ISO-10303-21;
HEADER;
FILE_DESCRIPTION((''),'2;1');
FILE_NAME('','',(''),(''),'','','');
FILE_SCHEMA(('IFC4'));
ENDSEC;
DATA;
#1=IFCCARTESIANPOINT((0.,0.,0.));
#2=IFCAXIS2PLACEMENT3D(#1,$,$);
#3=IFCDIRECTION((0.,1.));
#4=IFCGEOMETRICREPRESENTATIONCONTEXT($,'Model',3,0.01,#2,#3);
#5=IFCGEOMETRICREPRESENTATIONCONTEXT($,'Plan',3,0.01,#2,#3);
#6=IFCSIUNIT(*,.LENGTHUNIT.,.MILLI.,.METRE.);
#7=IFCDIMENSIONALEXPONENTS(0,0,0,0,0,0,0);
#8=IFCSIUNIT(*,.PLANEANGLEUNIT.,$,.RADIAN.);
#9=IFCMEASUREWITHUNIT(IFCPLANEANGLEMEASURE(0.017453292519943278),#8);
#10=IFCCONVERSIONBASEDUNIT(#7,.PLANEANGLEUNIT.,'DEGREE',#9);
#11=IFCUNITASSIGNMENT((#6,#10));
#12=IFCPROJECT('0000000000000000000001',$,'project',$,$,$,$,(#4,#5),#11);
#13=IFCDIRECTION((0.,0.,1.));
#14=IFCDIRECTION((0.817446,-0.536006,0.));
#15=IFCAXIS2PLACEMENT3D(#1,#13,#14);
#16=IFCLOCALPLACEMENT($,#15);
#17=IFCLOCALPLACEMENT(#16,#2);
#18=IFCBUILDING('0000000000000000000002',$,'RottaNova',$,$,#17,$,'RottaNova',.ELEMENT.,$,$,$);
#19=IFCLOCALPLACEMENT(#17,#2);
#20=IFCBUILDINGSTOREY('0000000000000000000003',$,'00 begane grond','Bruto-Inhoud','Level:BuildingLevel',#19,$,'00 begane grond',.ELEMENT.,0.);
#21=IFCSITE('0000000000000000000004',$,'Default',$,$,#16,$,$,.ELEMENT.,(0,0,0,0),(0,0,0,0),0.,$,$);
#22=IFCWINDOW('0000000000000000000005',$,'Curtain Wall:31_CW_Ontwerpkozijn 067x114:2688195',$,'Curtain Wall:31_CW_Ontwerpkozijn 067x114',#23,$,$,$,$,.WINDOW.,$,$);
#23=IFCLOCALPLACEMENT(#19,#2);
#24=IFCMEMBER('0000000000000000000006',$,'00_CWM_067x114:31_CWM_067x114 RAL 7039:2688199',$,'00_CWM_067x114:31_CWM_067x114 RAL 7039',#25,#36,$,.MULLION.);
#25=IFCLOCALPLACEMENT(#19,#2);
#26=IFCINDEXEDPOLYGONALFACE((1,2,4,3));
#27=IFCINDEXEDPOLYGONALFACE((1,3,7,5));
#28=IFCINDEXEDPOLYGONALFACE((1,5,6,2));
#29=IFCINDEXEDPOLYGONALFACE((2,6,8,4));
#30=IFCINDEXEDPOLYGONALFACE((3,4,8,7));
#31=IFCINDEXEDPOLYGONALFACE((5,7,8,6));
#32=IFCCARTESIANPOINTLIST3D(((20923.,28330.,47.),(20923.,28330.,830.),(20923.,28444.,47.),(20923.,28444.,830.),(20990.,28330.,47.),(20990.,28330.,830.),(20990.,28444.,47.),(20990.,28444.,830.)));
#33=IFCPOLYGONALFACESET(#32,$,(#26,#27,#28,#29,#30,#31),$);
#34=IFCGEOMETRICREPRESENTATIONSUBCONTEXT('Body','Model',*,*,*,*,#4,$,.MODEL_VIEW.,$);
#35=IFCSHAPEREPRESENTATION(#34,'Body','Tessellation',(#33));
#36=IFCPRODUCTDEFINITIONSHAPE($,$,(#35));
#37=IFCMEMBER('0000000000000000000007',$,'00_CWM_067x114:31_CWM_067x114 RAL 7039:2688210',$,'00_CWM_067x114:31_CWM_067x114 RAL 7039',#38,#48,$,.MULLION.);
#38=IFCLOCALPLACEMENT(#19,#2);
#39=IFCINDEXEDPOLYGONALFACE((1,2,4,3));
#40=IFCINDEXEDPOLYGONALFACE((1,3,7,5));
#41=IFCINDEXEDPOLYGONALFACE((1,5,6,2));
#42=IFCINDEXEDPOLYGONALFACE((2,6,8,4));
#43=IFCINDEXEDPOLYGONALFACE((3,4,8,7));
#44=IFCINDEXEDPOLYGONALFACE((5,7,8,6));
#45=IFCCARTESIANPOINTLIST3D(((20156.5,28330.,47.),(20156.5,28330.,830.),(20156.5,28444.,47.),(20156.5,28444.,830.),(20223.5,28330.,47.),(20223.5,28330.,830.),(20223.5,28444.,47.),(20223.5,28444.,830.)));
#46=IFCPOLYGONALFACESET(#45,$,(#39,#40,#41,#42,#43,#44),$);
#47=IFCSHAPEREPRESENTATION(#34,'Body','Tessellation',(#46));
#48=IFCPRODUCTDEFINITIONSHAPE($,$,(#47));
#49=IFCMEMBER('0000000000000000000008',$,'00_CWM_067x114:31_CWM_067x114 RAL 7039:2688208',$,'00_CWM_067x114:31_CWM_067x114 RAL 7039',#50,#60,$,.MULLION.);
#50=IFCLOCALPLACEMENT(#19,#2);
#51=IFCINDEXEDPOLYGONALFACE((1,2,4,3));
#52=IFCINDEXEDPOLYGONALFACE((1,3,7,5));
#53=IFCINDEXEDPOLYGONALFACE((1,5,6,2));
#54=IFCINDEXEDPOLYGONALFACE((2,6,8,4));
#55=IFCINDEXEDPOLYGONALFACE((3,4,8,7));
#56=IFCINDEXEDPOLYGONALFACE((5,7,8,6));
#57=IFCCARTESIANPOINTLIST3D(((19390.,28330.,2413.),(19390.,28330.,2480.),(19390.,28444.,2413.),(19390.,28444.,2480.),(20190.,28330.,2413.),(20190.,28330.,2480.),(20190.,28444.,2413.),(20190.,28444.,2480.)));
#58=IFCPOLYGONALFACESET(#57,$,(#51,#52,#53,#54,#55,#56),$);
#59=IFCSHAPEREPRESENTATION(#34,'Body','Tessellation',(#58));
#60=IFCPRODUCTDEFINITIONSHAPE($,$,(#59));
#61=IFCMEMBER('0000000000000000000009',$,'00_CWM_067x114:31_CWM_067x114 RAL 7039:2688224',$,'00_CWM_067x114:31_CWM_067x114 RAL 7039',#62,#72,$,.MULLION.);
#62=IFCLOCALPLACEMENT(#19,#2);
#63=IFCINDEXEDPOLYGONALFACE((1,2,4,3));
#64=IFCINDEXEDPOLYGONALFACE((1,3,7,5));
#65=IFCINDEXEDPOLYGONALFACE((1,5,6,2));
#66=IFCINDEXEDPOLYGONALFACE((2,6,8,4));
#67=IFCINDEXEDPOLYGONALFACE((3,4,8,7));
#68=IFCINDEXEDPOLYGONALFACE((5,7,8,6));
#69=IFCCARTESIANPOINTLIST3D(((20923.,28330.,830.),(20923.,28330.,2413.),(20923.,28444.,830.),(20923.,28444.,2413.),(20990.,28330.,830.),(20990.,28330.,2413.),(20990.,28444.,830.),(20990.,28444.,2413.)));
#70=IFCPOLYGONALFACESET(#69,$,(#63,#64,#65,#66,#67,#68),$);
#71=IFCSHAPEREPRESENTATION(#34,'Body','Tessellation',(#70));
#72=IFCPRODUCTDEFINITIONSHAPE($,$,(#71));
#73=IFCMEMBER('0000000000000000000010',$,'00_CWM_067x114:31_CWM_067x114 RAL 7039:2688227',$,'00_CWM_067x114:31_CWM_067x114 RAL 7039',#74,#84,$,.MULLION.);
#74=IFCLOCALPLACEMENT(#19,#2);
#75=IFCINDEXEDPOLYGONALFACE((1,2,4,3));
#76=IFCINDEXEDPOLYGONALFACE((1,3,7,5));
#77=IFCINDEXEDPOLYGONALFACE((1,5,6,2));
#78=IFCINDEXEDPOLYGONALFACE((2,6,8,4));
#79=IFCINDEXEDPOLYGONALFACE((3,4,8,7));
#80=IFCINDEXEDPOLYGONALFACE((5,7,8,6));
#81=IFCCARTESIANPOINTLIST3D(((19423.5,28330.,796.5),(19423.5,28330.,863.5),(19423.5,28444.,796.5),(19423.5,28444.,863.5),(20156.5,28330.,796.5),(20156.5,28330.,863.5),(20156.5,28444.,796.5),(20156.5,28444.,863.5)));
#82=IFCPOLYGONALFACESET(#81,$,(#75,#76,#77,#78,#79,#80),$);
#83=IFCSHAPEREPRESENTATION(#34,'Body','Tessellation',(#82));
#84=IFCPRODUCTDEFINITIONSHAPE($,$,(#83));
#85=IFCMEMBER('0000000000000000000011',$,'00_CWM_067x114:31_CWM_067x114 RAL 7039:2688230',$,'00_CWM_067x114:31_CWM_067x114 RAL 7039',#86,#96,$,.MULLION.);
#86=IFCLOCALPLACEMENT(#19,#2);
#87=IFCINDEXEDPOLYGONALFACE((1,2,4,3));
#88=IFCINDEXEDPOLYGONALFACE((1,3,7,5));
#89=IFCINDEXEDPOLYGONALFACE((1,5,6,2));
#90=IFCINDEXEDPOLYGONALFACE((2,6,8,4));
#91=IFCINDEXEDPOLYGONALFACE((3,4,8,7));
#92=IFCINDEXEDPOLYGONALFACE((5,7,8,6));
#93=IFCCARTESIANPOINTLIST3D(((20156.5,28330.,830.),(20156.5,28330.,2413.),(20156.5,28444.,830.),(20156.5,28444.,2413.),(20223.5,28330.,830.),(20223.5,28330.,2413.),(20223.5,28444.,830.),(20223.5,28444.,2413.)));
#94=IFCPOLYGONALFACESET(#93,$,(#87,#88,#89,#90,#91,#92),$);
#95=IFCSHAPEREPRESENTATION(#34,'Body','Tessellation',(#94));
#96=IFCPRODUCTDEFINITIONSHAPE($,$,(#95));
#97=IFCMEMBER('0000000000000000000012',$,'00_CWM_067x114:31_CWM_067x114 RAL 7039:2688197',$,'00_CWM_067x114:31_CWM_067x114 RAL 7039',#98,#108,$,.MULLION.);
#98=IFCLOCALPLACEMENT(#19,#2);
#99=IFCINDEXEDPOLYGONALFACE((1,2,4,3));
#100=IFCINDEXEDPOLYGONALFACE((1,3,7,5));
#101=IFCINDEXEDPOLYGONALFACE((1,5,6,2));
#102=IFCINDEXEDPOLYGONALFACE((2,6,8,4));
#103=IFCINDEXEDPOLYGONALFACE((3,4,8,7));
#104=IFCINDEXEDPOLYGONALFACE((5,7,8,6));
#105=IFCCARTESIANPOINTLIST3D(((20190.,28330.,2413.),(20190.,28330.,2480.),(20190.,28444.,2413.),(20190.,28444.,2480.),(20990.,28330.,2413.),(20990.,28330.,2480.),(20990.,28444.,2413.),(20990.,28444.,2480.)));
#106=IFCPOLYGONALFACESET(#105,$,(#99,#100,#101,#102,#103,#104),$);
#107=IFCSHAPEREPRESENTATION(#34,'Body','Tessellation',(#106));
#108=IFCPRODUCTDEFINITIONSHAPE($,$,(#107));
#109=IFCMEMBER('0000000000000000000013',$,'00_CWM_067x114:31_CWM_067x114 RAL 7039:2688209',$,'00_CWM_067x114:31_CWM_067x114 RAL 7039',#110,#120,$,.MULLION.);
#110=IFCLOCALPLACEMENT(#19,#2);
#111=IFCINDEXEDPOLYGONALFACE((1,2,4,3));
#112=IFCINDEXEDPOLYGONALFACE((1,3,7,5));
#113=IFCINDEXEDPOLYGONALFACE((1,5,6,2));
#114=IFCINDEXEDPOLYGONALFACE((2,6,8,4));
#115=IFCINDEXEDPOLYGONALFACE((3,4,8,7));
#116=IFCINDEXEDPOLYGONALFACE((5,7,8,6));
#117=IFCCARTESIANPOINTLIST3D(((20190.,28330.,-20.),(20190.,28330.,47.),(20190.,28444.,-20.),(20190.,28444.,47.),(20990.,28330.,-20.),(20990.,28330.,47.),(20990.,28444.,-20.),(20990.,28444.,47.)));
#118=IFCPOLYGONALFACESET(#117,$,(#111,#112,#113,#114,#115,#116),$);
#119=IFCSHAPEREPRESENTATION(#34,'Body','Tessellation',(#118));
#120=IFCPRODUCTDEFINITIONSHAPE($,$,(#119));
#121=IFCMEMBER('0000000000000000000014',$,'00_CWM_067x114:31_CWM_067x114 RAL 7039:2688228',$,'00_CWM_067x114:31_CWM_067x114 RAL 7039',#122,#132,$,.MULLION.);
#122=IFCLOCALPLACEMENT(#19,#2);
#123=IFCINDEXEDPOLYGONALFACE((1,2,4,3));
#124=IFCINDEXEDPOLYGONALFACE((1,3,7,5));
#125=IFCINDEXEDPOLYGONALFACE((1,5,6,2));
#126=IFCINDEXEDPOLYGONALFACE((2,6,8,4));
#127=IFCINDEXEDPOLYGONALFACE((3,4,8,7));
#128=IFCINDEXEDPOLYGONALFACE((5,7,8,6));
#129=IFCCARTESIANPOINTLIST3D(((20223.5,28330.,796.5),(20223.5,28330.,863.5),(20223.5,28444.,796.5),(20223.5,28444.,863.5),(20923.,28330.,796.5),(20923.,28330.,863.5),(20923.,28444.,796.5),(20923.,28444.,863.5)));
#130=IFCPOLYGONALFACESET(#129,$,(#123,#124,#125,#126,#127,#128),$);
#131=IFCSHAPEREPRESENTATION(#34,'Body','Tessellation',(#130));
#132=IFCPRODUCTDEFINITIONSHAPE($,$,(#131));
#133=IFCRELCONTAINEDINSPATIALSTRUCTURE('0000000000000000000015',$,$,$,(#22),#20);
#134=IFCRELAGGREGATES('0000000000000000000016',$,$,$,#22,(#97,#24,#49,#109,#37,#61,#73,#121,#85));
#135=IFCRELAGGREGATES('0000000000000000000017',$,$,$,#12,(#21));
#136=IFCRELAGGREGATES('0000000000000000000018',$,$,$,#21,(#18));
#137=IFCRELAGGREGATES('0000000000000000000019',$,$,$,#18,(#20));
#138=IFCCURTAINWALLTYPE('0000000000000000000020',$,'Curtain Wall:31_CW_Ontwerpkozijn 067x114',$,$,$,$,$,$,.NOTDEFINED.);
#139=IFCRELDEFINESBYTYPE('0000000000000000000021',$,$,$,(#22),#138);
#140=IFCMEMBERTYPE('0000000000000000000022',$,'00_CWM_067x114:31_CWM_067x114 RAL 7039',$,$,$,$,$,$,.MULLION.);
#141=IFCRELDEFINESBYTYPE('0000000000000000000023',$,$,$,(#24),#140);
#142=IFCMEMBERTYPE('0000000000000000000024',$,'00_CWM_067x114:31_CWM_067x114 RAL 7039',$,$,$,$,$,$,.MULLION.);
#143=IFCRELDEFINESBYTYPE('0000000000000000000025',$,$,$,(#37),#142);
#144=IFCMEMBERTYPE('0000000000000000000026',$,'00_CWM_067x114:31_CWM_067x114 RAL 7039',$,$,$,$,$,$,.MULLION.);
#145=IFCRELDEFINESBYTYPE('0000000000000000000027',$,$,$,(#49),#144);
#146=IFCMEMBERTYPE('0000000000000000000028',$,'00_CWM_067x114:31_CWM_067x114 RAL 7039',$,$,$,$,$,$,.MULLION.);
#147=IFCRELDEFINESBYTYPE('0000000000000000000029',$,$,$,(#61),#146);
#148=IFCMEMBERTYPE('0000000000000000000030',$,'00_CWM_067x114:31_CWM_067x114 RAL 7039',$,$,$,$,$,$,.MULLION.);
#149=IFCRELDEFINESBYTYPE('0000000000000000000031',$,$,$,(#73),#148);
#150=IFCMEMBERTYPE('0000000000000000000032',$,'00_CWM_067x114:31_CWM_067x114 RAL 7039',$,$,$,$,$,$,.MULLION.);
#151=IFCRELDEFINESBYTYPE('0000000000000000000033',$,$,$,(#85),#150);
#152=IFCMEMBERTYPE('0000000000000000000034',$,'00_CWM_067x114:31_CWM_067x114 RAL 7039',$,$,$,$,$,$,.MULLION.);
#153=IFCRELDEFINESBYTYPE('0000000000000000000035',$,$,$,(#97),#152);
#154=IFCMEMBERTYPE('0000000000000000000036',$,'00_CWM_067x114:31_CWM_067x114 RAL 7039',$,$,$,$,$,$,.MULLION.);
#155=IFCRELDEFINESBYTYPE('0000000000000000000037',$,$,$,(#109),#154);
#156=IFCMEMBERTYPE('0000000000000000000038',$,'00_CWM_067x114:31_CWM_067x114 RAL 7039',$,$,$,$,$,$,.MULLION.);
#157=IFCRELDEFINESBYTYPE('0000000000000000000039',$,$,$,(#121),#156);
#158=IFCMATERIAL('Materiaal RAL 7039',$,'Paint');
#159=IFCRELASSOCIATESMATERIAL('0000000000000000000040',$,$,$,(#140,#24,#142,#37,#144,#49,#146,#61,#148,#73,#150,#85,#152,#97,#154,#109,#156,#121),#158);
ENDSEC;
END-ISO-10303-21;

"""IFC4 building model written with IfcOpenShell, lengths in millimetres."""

from ifc_helpers import new_model, entity, si_unit, converted_unit, direction, frame, origin, place, context, subcontext, project, spatial, indexed_curve, outline, extrude, source, transform, mapped, material, type_object, type_shapes, element, aggregate, save


model = new_model("IFC4")

# Units and contexts
model_context = context("Model", 3, precision=0.01, world=origin(), true_north=direction((0.0, 1.0)))
plan_context = context("Plan", 3, precision=0.01, world=origin(), true_north=direction((0.0, 1.0)))
body_context = subcontext(model_context, "Body", "Model", "MODEL_VIEW")
ifc_project = project(units=[si_unit("LENGTHUNIT", "METRE", prefix="MILLI"), converted_unit("PLANEANGLEUNIT", "DEGREE", entity("IfcPlaneAngleMeasure", 0.017453292519943278), si_unit("PLANEANGLEUNIT", "RADIAN"), dimensions=[0, 0, 0, 0, 0, 0, 0])], contexts=[model_context, plan_context])

# Site, building, storey
site_placement = place(None, frame((0.0, 0.0, 0.0), z_axis=(0.0, 0.0, 1.0), x_axis=(0.817446, -0.536006, 0.0)))
site = spatial("IfcSite", under=ifc_project, at=site_placement, Name="Default", CompositionType="ELEMENT", RefLatitude=(0, 0, 0, 0), RefLongitude=(0, 0, 0, 0), RefElevation=0.0)
building_placement = place(site_placement, origin())
building = spatial("IfcBuilding", under=site, at=building_placement, Name="RottaNova", LongName="RottaNova", CompositionType="ELEMENT")
storey_placement = place(building_placement, origin())
storey = spatial("IfcBuildingStorey", under=building, at=storey_placement, Name="00 begane grond", Description="Bruto-Inhoud", ObjectType="Level:BuildingLevel", LongName="00 begane grond", CompositionType="ELEMENT", Elevation=0.0)

# Window, members
curtain_wall_type = type_object("IfcCurtainWallType", Name="Curtain Wall:31_CW_Ontwerpkozijn 067x114", PredefinedType="NOTDEFINED")
window_1_placement = place(storey_placement, origin())
window_1 = element("IfcWindow", 1, at=window_1_placement, inside=storey, type_object=curtain_wall_type, Name="Curtain Wall:31_CW_Ontwerpkozijn 067x114:2688195", ObjectType="Curtain Wall:31_CW_Ontwerpkozijn 067x114", PredefinedType="WINDOW")
ifc_material_1 = material(Name="Materiaal RAL 7039", Category="Paint")
member_type_1 = type_object("IfcMemberType", Name="00_CWM_067x114:31_CWM_067x114 RAL 7039", PredefinedType="MULLION", material=ifc_material_1)
shared_shape_1 = source(origin(), body_context, "Body", "SweptSolid", [
    extrude(outline(indexed_curve([(-33.5, -57.0), (33.5, -57.0), (33.5, 57.0), (-33.5, 57.0), (-33.5, -57.0)], self_intersect=False)), frame((-33.5, -57.0, -783.0), z_axis=(0.0, 0.0, 1.0), x_axis=(-1.0, 0.0, 0.0)), (0.0, 0.0, 1.0), 783.0),
])
type_shapes(member_type_1, [shared_shape_1])
member_1_placement = place(window_1_placement, frame((20990.0, 28330.0, 47.0), z_axis=(0.0, 0.0, -1.0), x_axis=(1.0, 0.0, 0.0)))
member_1 = element("IfcMember", 2, at=member_1_placement, type_object=member_type_1, material=ifc_material_1, Name="00_CWM_067x114:31_CWM_067x114 RAL 7039:2688199", ObjectType="00_CWM_067x114:31_CWM_067x114 RAL 7039", PredefinedType="MULLION", context=body_context, shape_type="MappedRepresentation", body=[
    mapped(shared_shape_1, transform((0.0, 0.0, 0.0), scale=1.0)),
])
member_type_2 = type_object("IfcMemberType", Name="00_CWM_067x114:31_CWM_067x114 RAL 7039", PredefinedType="MULLION", material=ifc_material_1)
shared_shape_2 = source(origin(), body_context, "Body", "SweptSolid", [
    extrude(outline(indexed_curve([(-33.5, -57.0), (33.5, -57.0), (33.5, 57.0), (-33.5, 57.0), (-33.5, -57.0)], self_intersect=False)), frame((0.0, -57.0, -783.0), z_axis=(0.0, 0.0, 1.0), x_axis=(-1.0, 0.0, 0.0)), (0.0, 0.0, 1.0), 783.0),
])
type_shapes(member_type_2, [shared_shape_2])
member_2_placement = place(window_1_placement, frame((20190.0, 28330.0, 47.0), z_axis=(0.0, 0.0, -1.0), x_axis=(1.0, 0.0, 0.0)))
member_2 = element("IfcMember", 3, at=member_2_placement, type_object=member_type_2, material=ifc_material_1, Name="00_CWM_067x114:31_CWM_067x114 RAL 7039:2688210", ObjectType="00_CWM_067x114:31_CWM_067x114 RAL 7039", PredefinedType="MULLION", context=body_context, shape_type="MappedRepresentation", body=[
    mapped(shared_shape_2, transform((0.0, 0.0, 0.0), scale=1.0)),
])
member_type_3 = type_object("IfcMemberType", Name="00_CWM_067x114:31_CWM_067x114 RAL 7039", PredefinedType="MULLION", material=ifc_material_1)
shared_shape_3 = source(origin(), body_context, "Body", "SweptSolid", [
    extrude(outline(indexed_curve([(-33.5, -57.0), (33.5, -57.0), (33.5, 57.0), (-33.5, 57.0), (-33.5, -57.0)], self_intersect=False)), frame((-33.5, -57.0, -800.0), z_axis=(0.0, 0.0, 1.0), x_axis=(-1.0, 0.0, 0.0)), (0.0, 0.0, 1.0), 800.0),
])
type_shapes(member_type_3, [shared_shape_3])
member_3_placement = place(window_1_placement, frame((20190.0, 28330.0, 2480.0), z_axis=(1.0, 0.0, 0.0), x_axis=(0.0, 0.0, 1.0)))
member_3 = element("IfcMember", 4, at=member_3_placement, type_object=member_type_3, material=ifc_material_1, Name="00_CWM_067x114:31_CWM_067x114 RAL 7039:2688208", ObjectType="00_CWM_067x114:31_CWM_067x114 RAL 7039", PredefinedType="MULLION", context=body_context, shape_type="MappedRepresentation", body=[
    mapped(shared_shape_3, transform((0.0, 0.0, 0.0), scale=1.0)),
])
member_type_4 = type_object("IfcMemberType", Name="00_CWM_067x114:31_CWM_067x114 RAL 7039", PredefinedType="MULLION", material=ifc_material_1)
shared_shape_4 = source(origin(), body_context, "Body", "SweptSolid", [
    extrude(outline(indexed_curve([(-33.5, -57.0), (33.5, -57.0), (33.5, 57.0), (-33.5, 57.0), (-33.5, -57.0)], self_intersect=False)), frame((-33.5, -57.0, -1583.0), z_axis=(0.0, 0.0, 1.0), x_axis=(-1.0, 0.0, 0.0)), (0.0, 0.0, 1.0), 1583.0),
])
type_shapes(member_type_4, [shared_shape_4])
member_4_placement = place(window_1_placement, frame((20990.0, 28330.0, 830.0), z_axis=(0.0, 0.0, -1.0), x_axis=(1.0, 0.0, 0.0)))
member_4 = element("IfcMember", 5, at=member_4_placement, type_object=member_type_4, material=ifc_material_1, Name="00_CWM_067x114:31_CWM_067x114 RAL 7039:2688224", ObjectType="00_CWM_067x114:31_CWM_067x114 RAL 7039", PredefinedType="MULLION", context=body_context, shape_type="MappedRepresentation", body=[
    mapped(shared_shape_4, transform((0.0, 0.0, 0.0), scale=1.0)),
])
member_type_5 = type_object("IfcMemberType", Name="00_CWM_067x114:31_CWM_067x114 RAL 7039", PredefinedType="MULLION", material=ifc_material_1)
shared_shape_5 = source(origin(), body_context, "Body", "SweptSolid", [
    extrude(outline(indexed_curve([(-33.5, -57.0), (33.5, -57.0), (33.5, 57.0), (-33.5, 57.0), (-33.5, -57.0)], self_intersect=False)), frame((0.0, -57.0, -733.0), z_axis=(0.0, 0.0, 1.0), x_axis=(-1.0, 0.0, 0.0)), (0.0, 0.0, 1.0), 733.0),
])
type_shapes(member_type_5, [shared_shape_5])
member_5_placement = place(window_1_placement, frame((20156.5, 28330.0, 830.0), z_axis=(1.0, 0.0, 0.0), x_axis=(0.0, 0.0, 1.0)))
member_5 = element("IfcMember", 6, at=member_5_placement, type_object=member_type_5, material=ifc_material_1, Name="00_CWM_067x114:31_CWM_067x114 RAL 7039:2688227", ObjectType="00_CWM_067x114:31_CWM_067x114 RAL 7039", PredefinedType="MULLION", context=body_context, shape_type="MappedRepresentation", body=[
    mapped(shared_shape_5, transform((0.0, 0.0, 0.0), scale=1.0)),
])
member_type_6 = type_object("IfcMemberType", Name="00_CWM_067x114:31_CWM_067x114 RAL 7039", PredefinedType="MULLION", material=ifc_material_1)
shared_shape_6 = source(origin(), body_context, "Body", "SweptSolid", [
    extrude(outline(indexed_curve([(-33.5, -57.0), (33.5, -57.0), (33.5, 57.0), (-33.5, 57.0), (-33.5, -57.0)], self_intersect=False)), frame((0.0, -57.0, -1583.0), z_axis=(0.0, 0.0, 1.0), x_axis=(-1.0, 0.0, 0.0)), (0.0, 0.0, 1.0), 1583.0),
])
type_shapes(member_type_6, [shared_shape_6])
member_6_placement = place(window_1_placement, frame((20190.0, 28330.0, 830.0), z_axis=(0.0, 0.0, -1.0), x_axis=(1.0, 0.0, 0.0)))
member_6 = element("IfcMember", 7, at=member_6_placement, type_object=member_type_6, material=ifc_material_1, Name="00_CWM_067x114:31_CWM_067x114 RAL 7039:2688230", ObjectType="00_CWM_067x114:31_CWM_067x114 RAL 7039", PredefinedType="MULLION", context=body_context, shape_type="MappedRepresentation", body=[
    mapped(shared_shape_6, transform((0.0, 0.0, 0.0), scale=1.0)),
])
member_type_7 = type_object("IfcMemberType", Name="00_CWM_067x114:31_CWM_067x114 RAL 7039", PredefinedType="MULLION", material=ifc_material_1)
shared_shape_7 = source(origin(), body_context, "Body", "SweptSolid", [
    extrude(outline(indexed_curve([(-33.5, -57.0), (33.5, -57.0), (33.5, 57.0), (-33.5, 57.0), (-33.5, -57.0)], self_intersect=False)), frame((-33.5, -57.0, -800.0), z_axis=(0.0, 0.0, 1.0), x_axis=(-1.0, 0.0, 0.0)), (0.0, 0.0, 1.0), 800.0),
])
type_shapes(member_type_7, [shared_shape_7])
member_7_placement = place(window_1_placement, frame((20990.0, 28330.0, 2480.0), z_axis=(1.0, 0.0, 0.0), x_axis=(0.0, 0.0, 1.0)))
member_7 = element("IfcMember", 8, at=member_7_placement, type_object=member_type_7, material=ifc_material_1, Name="00_CWM_067x114:31_CWM_067x114 RAL 7039:2688197", ObjectType="00_CWM_067x114:31_CWM_067x114 RAL 7039", PredefinedType="MULLION", context=body_context, shape_type="MappedRepresentation", body=[
    mapped(shared_shape_7, transform((0.0, 0.0, 0.0), scale=1.0)),
])
member_type_8 = type_object("IfcMemberType", Name="00_CWM_067x114:31_CWM_067x114 RAL 7039", PredefinedType="MULLION", material=ifc_material_1)
shared_shape_8 = source(origin(), body_context, "Body", "SweptSolid", [
    extrude(outline(indexed_curve([(-33.5, -57.0), (33.5, -57.0), (33.5, 57.0), (-33.5, 57.0), (-33.5, -57.0)], self_intersect=False)), frame((-33.5, -57.0, -800.0), z_axis=(0.0, 0.0, 1.0), x_axis=(-1.0, 0.0, 0.0)), (0.0, 0.0, 1.0), 800.0),
])
type_shapes(member_type_8, [shared_shape_8])
member_8_placement = place(window_1_placement, frame((20190.0, 28330.0, -20.0), z_axis=(-1.0, 0.0, 0.0), x_axis=(0.0, 0.0, -1.0)))
member_8 = element("IfcMember", 9, at=member_8_placement, type_object=member_type_8, material=ifc_material_1, Name="00_CWM_067x114:31_CWM_067x114 RAL 7039:2688209", ObjectType="00_CWM_067x114:31_CWM_067x114 RAL 7039", PredefinedType="MULLION", context=body_context, shape_type="MappedRepresentation", body=[
    mapped(shared_shape_8, transform((0.0, 0.0, 0.0), scale=1.0)),
])
member_type_9 = type_object("IfcMemberType", Name="00_CWM_067x114:31_CWM_067x114 RAL 7039", PredefinedType="MULLION", material=ifc_material_1)
shared_shape_9 = source(origin(), body_context, "Body", "SweptSolid", [
    extrude(outline(indexed_curve([(-33.5, -57.0), (33.5, -57.0), (33.5, 57.0), (-33.5, 57.0), (-33.5, -57.0)], self_intersect=False)), frame((0.0, -57.0, -699.5), z_axis=(0.0, 0.0, 1.0), x_axis=(-1.0, 0.0, 0.0)), (0.0, 0.0, 1.0), 699.5),
])
type_shapes(member_type_9, [shared_shape_9])
member_9_placement = place(window_1_placement, frame((20923.0, 28330.0, 830.0), z_axis=(1.0, 0.0, 0.0), x_axis=(0.0, 0.0, 1.0)))
member_9 = element("IfcMember", 10, at=member_9_placement, type_object=member_type_9, material=ifc_material_1, Name="00_CWM_067x114:31_CWM_067x114 RAL 7039:2688228", ObjectType="00_CWM_067x114:31_CWM_067x114 RAL 7039", PredefinedType="MULLION", context=body_context, shape_type="MappedRepresentation", body=[
    mapped(shared_shape_9, transform((0.0, 0.0, 0.0), scale=1.0)),
])
aggregate(window_1, [member_7, member_1, member_3, member_8, member_2, member_4, member_5, member_9, member_6])

save(model, "model.ifc")
